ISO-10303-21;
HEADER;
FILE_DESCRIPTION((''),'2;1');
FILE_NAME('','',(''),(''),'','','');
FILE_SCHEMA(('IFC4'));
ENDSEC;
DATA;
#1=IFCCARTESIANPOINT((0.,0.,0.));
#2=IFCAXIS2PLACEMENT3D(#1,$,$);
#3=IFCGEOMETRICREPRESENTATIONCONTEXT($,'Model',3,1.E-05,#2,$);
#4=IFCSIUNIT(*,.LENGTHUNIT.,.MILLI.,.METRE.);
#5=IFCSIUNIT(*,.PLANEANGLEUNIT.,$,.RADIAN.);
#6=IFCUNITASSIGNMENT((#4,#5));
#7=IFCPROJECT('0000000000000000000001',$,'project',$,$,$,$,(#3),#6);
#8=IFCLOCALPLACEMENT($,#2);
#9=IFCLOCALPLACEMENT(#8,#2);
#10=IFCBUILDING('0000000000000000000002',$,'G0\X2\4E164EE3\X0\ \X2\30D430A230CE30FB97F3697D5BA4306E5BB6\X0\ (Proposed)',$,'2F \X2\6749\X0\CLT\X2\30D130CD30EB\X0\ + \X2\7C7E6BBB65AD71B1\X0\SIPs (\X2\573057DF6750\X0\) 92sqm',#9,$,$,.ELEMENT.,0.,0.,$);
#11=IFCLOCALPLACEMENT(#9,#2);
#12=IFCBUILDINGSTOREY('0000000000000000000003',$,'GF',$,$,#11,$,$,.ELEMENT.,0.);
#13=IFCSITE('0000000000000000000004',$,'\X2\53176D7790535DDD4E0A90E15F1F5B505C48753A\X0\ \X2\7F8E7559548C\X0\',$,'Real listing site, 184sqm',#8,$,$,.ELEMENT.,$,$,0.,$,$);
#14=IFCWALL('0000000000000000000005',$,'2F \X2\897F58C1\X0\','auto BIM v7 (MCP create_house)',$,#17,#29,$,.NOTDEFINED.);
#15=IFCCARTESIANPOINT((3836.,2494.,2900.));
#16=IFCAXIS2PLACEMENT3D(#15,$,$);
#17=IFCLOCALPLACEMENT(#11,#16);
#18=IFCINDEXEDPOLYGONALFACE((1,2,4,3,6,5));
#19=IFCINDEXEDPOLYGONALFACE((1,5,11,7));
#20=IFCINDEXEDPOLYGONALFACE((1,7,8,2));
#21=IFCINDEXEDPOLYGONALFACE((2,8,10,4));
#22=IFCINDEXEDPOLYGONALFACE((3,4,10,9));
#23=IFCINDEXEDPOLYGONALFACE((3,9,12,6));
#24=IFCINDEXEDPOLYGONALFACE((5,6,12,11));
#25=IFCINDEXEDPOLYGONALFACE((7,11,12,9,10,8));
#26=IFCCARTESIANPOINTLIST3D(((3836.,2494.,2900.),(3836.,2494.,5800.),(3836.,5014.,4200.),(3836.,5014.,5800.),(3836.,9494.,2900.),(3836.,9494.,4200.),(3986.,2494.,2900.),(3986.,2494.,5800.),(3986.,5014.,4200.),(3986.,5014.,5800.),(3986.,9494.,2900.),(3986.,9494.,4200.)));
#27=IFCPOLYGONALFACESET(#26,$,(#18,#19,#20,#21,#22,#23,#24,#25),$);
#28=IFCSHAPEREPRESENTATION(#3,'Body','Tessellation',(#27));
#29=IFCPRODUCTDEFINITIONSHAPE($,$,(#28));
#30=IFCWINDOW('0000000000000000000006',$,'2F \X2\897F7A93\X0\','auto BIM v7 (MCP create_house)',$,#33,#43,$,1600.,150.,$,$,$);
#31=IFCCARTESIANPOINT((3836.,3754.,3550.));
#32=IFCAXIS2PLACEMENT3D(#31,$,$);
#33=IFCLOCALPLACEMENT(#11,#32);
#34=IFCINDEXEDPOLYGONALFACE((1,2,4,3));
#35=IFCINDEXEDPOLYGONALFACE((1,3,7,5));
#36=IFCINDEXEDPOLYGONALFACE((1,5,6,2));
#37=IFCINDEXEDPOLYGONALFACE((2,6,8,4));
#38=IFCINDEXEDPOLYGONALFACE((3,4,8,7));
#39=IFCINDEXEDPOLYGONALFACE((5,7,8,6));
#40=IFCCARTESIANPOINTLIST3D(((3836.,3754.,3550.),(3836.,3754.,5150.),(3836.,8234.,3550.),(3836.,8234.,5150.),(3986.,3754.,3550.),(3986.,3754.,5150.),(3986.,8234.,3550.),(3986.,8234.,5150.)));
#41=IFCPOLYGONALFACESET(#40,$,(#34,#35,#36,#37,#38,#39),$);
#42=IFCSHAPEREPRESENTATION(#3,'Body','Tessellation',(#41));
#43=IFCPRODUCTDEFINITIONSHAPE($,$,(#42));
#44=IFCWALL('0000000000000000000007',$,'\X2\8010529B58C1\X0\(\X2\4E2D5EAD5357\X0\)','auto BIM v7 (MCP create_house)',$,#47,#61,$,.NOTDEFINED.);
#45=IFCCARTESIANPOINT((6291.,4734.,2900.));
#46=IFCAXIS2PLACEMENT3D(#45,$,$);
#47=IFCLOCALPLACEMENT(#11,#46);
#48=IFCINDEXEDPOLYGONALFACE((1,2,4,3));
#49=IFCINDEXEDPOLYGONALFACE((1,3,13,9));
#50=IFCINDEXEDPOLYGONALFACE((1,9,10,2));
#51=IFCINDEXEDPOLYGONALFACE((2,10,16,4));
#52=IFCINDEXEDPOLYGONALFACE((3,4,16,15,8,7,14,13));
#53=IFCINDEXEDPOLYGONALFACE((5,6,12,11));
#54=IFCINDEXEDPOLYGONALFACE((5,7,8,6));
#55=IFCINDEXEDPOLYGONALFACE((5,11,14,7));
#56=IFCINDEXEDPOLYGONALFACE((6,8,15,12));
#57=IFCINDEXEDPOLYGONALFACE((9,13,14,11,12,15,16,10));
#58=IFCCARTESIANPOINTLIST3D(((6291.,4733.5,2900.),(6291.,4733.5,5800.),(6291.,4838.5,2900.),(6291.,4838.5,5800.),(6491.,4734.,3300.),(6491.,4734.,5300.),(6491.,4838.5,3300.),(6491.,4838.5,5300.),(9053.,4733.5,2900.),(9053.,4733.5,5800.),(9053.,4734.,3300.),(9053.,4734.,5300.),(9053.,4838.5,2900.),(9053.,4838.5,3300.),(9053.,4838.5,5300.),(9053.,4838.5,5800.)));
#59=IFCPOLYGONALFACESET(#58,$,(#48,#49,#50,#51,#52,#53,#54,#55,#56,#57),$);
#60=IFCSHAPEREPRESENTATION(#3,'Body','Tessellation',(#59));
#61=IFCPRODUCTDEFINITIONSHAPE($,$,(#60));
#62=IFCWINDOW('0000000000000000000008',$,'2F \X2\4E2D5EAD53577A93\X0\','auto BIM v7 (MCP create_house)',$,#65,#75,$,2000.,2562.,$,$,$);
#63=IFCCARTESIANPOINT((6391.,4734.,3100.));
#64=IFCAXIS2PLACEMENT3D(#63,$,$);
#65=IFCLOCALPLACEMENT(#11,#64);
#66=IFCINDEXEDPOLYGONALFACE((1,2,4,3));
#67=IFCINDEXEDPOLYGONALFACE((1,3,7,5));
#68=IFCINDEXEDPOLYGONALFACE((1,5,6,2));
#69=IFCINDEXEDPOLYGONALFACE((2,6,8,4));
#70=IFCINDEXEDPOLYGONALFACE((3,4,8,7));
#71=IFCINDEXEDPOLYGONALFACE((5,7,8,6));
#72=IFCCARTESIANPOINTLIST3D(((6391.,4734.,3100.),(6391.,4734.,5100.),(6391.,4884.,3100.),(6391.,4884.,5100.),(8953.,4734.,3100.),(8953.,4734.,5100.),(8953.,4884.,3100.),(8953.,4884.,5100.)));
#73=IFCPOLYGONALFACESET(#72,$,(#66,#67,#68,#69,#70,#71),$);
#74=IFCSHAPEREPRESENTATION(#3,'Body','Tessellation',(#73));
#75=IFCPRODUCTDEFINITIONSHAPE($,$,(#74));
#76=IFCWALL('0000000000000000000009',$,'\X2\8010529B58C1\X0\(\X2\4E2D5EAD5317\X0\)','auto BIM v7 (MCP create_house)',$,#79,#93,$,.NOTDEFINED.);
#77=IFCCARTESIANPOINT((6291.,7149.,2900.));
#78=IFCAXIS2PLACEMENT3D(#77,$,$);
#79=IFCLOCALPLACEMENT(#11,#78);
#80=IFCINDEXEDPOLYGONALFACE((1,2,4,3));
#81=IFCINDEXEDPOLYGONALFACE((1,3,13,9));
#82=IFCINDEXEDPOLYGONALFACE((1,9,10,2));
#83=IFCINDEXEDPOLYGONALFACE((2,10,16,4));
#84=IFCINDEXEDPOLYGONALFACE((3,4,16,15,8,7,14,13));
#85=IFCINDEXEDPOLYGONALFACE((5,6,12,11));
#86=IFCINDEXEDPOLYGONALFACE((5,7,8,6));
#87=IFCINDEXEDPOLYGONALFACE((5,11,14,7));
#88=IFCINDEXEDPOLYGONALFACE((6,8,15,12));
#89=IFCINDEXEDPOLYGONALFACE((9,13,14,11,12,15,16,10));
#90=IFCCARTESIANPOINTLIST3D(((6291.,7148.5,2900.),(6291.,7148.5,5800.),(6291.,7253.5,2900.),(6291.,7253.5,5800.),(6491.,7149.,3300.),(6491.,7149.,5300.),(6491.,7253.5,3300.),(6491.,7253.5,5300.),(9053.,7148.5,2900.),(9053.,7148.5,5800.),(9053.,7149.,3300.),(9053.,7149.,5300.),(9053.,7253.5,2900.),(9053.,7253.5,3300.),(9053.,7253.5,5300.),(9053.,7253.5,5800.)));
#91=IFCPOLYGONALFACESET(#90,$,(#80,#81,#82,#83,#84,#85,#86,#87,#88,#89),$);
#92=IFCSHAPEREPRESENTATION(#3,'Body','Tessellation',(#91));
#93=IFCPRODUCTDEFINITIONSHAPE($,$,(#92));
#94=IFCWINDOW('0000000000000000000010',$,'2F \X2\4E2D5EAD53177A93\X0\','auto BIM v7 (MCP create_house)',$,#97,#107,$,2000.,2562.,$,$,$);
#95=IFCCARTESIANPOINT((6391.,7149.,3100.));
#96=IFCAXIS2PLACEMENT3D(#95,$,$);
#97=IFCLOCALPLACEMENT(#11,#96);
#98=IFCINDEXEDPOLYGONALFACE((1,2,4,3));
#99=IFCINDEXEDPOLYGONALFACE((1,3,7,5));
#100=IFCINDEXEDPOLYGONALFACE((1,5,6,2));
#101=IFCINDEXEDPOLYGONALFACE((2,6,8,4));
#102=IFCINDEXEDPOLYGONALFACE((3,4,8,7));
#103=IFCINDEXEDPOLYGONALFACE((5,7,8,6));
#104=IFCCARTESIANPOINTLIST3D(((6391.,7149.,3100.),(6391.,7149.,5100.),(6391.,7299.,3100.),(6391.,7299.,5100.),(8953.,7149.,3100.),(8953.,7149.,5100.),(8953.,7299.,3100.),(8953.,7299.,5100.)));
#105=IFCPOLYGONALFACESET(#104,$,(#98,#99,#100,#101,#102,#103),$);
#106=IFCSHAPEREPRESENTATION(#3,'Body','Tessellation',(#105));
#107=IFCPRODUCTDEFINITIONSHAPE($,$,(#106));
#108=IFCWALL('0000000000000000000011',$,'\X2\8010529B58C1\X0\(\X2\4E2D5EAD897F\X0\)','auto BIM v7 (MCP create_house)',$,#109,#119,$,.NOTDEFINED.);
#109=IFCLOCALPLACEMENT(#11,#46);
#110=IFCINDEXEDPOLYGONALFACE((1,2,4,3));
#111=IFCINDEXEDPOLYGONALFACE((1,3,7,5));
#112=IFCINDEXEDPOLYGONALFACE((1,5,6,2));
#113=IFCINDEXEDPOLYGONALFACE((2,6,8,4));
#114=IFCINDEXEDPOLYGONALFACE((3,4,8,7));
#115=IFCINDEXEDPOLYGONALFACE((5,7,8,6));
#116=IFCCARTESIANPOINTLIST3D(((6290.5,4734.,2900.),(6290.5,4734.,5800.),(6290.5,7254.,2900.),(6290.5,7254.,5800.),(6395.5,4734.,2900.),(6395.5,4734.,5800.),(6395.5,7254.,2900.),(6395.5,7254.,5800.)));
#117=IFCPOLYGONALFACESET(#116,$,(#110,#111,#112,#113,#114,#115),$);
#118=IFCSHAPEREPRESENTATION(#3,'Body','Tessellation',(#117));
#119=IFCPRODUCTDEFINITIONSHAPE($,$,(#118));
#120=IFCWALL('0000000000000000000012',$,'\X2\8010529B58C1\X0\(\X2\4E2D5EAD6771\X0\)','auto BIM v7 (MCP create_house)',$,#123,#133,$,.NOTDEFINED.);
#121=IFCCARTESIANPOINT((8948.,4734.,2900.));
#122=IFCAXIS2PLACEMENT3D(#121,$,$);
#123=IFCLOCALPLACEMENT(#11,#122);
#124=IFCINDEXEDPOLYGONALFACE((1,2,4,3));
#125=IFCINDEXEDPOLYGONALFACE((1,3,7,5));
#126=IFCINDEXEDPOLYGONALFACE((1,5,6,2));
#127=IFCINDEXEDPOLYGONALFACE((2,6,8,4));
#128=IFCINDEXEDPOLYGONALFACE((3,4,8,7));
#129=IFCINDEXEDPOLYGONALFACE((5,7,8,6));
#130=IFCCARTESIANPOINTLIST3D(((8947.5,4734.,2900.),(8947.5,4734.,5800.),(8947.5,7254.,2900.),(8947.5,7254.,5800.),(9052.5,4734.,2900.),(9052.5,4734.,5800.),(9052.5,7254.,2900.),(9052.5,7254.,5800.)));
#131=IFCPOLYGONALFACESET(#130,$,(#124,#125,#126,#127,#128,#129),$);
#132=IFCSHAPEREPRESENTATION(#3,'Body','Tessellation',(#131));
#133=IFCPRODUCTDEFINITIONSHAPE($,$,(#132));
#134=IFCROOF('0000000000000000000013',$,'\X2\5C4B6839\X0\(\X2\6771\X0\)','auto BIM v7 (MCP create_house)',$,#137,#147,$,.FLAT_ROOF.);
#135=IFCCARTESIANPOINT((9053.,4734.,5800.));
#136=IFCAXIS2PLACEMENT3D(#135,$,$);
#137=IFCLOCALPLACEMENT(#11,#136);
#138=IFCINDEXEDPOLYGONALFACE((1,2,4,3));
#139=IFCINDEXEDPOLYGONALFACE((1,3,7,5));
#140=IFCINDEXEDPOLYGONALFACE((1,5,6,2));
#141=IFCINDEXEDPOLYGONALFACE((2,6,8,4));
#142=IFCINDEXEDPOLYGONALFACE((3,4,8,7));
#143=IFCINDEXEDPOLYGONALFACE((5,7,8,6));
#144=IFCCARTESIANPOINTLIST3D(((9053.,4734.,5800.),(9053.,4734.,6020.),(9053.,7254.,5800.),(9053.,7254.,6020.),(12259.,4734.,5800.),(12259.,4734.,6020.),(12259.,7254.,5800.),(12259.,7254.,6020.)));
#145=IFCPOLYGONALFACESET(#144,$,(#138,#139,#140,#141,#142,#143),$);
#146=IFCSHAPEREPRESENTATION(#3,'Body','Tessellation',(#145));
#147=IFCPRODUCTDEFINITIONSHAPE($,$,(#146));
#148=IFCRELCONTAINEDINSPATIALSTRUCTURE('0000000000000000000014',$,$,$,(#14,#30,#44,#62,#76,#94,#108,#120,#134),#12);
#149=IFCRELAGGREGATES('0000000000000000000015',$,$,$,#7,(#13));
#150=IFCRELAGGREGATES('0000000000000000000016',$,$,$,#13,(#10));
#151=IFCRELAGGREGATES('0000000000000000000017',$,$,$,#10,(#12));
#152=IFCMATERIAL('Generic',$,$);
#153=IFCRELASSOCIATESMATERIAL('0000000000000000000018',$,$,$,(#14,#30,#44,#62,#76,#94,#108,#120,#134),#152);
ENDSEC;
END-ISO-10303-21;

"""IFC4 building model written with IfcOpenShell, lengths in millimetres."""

from ifc_helpers import new_model, si_unit, frame, frame_2d, origin, place, context, project, spatial, rectangle, extrude, material, element, fill, save


model = new_model("IFC4")

# Units and contexts
model_context = context("Model", 3, precision=1e-05, world=origin())
ifc_project = project(units=[si_unit("LENGTHUNIT", "METRE", prefix="MILLI"), si_unit("PLANEANGLEUNIT", "RADIAN")], contexts=[model_context])

# Site, building, storey
site_placement = place(None, origin())
site = spatial("IfcSite", under=ifc_project, at=site_placement, Name="北海道川上郡弟子屈町 美留和", ObjectType="Real listing site, 184sqm", CompositionType="ELEMENT", RefElevation=0.0)
building_placement = place(site_placement, origin())
building = spatial("IfcBuilding", under=site, at=building_placement, Name="G0世代 ピアノ・音楽室の家 (Proposed)", ObjectType="2F 杉CLTパネル + 籾殻断熱SIPs (地域材) 92sqm", CompositionType="ELEMENT", ElevationOfRefHeight=0.0, ElevationOfTerrain=0.0)
storey_placement = place(building_placement, origin())
storey = spatial("IfcBuildingStorey", under=building, at=storey_placement, Name="GF", CompositionType="ELEMENT", Elevation=0.0)

# Shared definitions
ifc_material = material(Name="Generic")

# Walls, openings, windows
wall_1_placement = place(storey_placement, frame((3836.0, 2494.0, 2900.0)))
wall_1 = element("IfcWall", 1, at=wall_1_placement, inside=storey, material=ifc_material, Name="2F 西壁", Description="auto BIM v7 (MCP create_house)", PredefinedType="NOTDEFINED", context=model_context, shape_type="SweptSolid", body=[
    extrude(rectangle(XDim=150.0, YDim=7000.0, at=frame_2d((75.0, 3500.0))), frame((3836.0, 2494.0, 2900.0)), (0.0, 0.0, 1.0), 2900.0),
])
opening_1_placement = place(storey_placement, frame((3836.0, 3754.0, 3550.0)))
opening_1 = element("IfcOpeningElement", 2, at=opening_1_placement, cuts=wall_1, PredefinedType="NOTDEFINED", context=model_context, shape_type="SweptSolid", body=[
    extrude(rectangle(XDim=150.0, YDim=4480.0, at=frame_2d((75.0, 2240.0))), frame((3836.0, 3754.0, 3550.0)), (0.0, 0.0, 1.0), 1600.0),
])
window_1_placement = place(storey_placement, frame((3836.0, 3754.0, 3550.0)))
window_1 = element("IfcWindow", 3, at=window_1_placement, inside=storey, material=ifc_material, Name="2F 西窓", Description="auto BIM v7 (MCP create_house)", OverallHeight=1600.0, OverallWidth=150.0, context=model_context, shape_type="SweptSolid", body=[
    extrude(rectangle(XDim=150.0, YDim=4480.0, at=frame_2d((75.0, 2240.0))), frame((3836.0, 3754.0, 3550.0)), (0.0, 0.0, 1.0), 1600.0),
])
fill(opening_1, window_1)
wall_2_placement = place(storey_placement, frame((6291.0, 4734.0, 2900.0)))
wall_2 = element("IfcWall", 4, at=wall_2_placement, inside=storey, material=ifc_material, Name="耐力壁(中庭南)", Description="auto BIM v7 (MCP create_house)", PredefinedType="NOTDEFINED", context=model_context, shape_type="SweptSolid", body=[
    extrude(rectangle(XDim=2762.0, YDim=105.0, at=frame_2d((1381.0, 52.0))), frame((6291.0, 4734.0, 2900.0)), (0.0, 0.0, 1.0), 2900.0),
])
opening_2_placement = place(storey_placement, frame((6391.0, 4734.0, 3100.0)))
opening_2 = element("IfcOpeningElement", 5, at=opening_2_placement, cuts=wall_2, PredefinedType="NOTDEFINED", context=model_context, shape_type="SweptSolid", body=[
    extrude(rectangle(XDim=2562.0, YDim=150.0, at=frame_2d((1281.0, 75.0))), frame((6391.0, 4734.0, 3100.0)), (0.0, 0.0, 1.0), 2000.0),
])
window_2_placement = place(storey_placement, frame((6391.0, 4734.0, 3100.0)))
window_2 = element("IfcWindow", 6, at=window_2_placement, inside=storey, material=ifc_material, Name="2F 中庭南窓", Description="auto BIM v7 (MCP create_house)", OverallHeight=2000.0, OverallWidth=2562.0, context=model_context, shape_type="SweptSolid", body=[
    extrude(rectangle(XDim=2562.0, YDim=150.0, at=frame_2d((1281.0, 75.0))), frame((6391.0, 4734.0, 3100.0)), (0.0, 0.0, 1.0), 2000.0),
])
fill(opening_2, window_2)
wall_3_placement = place(storey_placement, frame((6291.0, 7149.0, 2900.0)))
wall_3 = element("IfcWall", 7, at=wall_3_placement, inside=storey, material=ifc_material, Name="耐力壁(中庭北)", Description="auto BIM v7 (MCP create_house)", PredefinedType="NOTDEFINED", context=model_context, shape_type="SweptSolid", body=[
    extrude(rectangle(XDim=2762.0, YDim=105.0, at=frame_2d((1381.0, 52.0))), frame((6291.0, 7149.0, 2900.0)), (0.0, 0.0, 1.0), 2900.0),
])
opening_3_placement = place(storey_placement, frame((6391.0, 7149.0, 3100.0)))
opening_3 = element("IfcOpeningElement", 8, at=opening_3_placement, cuts=wall_3, PredefinedType="NOTDEFINED", context=model_context, shape_type="SweptSolid", body=[
    extrude(rectangle(XDim=2562.0, YDim=150.0, at=frame_2d((1281.0, 75.0))), frame((6391.0, 7149.0, 3100.0)), (0.0, 0.0, 1.0), 2000.0),
])
window_3_placement = place(storey_placement, frame((6391.0, 7149.0, 3100.0)))
window_3 = element("IfcWindow", 9, at=window_3_placement, inside=storey, material=ifc_material, Name="2F 中庭北窓", Description="auto BIM v7 (MCP create_house)", OverallHeight=2000.0, OverallWidth=2562.0, context=model_context, shape_type="SweptSolid", body=[
    extrude(rectangle(XDim=2562.0, YDim=150.0, at=frame_2d((1281.0, 75.0))), frame((6391.0, 7149.0, 3100.0)), (0.0, 0.0, 1.0), 2000.0),
])
fill(opening_3, window_3)

# Walls
wall_4_placement = place(storey_placement, frame((6291.0, 4734.0, 2900.0)))
element("IfcWall", 10, at=wall_4_placement, inside=storey, material=ifc_material, Name="耐力壁(中庭西)", Description="auto BIM v7 (MCP create_house)", PredefinedType="NOTDEFINED", context=model_context, shape_type="SweptSolid", body=[
    extrude(rectangle(XDim=105.0, YDim=2520.0, at=frame_2d((52.0, 1260.0))), frame((6291.0, 4734.0, 2900.0)), (0.0, 0.0, 1.0), 2900.0),
])
wall_5_placement = place(storey_placement, frame((8948.0, 4734.0, 2900.0)))
element("IfcWall", 11, at=wall_5_placement, inside=storey, material=ifc_material, Name="耐力壁(中庭東)", Description="auto BIM v7 (MCP create_house)", PredefinedType="NOTDEFINED", context=model_context, shape_type="SweptSolid", body=[
    extrude(rectangle(XDim=105.0, YDim=2520.0, at=frame_2d((52.0, 1260.0))), frame((8948.0, 4734.0, 2900.0)), (0.0, 0.0, 1.0), 2900.0),
])

# Roof
for number, where, name in (
    (12, (9053.0, 4734.0, 5800.0), "屋根(東)"),
):
    element("IfcRoof", number, at=place(storey_placement, frame(where)), inside=storey, material=ifc_material, Name=name, Description="auto BIM v7 (MCP create_house)", PredefinedType="FLAT_ROOF", context=model_context, shape_type="SweptSolid", body=[
        extrude(rectangle(XDim=3206.0, YDim=2520.0, at=frame_2d((1603.0, 1260.0))), frame((9053.0, 4734.0, 5800.0)), (0.0, 0.0, 1.0), 220.0),
    ])

save(model, "model.ifc")
